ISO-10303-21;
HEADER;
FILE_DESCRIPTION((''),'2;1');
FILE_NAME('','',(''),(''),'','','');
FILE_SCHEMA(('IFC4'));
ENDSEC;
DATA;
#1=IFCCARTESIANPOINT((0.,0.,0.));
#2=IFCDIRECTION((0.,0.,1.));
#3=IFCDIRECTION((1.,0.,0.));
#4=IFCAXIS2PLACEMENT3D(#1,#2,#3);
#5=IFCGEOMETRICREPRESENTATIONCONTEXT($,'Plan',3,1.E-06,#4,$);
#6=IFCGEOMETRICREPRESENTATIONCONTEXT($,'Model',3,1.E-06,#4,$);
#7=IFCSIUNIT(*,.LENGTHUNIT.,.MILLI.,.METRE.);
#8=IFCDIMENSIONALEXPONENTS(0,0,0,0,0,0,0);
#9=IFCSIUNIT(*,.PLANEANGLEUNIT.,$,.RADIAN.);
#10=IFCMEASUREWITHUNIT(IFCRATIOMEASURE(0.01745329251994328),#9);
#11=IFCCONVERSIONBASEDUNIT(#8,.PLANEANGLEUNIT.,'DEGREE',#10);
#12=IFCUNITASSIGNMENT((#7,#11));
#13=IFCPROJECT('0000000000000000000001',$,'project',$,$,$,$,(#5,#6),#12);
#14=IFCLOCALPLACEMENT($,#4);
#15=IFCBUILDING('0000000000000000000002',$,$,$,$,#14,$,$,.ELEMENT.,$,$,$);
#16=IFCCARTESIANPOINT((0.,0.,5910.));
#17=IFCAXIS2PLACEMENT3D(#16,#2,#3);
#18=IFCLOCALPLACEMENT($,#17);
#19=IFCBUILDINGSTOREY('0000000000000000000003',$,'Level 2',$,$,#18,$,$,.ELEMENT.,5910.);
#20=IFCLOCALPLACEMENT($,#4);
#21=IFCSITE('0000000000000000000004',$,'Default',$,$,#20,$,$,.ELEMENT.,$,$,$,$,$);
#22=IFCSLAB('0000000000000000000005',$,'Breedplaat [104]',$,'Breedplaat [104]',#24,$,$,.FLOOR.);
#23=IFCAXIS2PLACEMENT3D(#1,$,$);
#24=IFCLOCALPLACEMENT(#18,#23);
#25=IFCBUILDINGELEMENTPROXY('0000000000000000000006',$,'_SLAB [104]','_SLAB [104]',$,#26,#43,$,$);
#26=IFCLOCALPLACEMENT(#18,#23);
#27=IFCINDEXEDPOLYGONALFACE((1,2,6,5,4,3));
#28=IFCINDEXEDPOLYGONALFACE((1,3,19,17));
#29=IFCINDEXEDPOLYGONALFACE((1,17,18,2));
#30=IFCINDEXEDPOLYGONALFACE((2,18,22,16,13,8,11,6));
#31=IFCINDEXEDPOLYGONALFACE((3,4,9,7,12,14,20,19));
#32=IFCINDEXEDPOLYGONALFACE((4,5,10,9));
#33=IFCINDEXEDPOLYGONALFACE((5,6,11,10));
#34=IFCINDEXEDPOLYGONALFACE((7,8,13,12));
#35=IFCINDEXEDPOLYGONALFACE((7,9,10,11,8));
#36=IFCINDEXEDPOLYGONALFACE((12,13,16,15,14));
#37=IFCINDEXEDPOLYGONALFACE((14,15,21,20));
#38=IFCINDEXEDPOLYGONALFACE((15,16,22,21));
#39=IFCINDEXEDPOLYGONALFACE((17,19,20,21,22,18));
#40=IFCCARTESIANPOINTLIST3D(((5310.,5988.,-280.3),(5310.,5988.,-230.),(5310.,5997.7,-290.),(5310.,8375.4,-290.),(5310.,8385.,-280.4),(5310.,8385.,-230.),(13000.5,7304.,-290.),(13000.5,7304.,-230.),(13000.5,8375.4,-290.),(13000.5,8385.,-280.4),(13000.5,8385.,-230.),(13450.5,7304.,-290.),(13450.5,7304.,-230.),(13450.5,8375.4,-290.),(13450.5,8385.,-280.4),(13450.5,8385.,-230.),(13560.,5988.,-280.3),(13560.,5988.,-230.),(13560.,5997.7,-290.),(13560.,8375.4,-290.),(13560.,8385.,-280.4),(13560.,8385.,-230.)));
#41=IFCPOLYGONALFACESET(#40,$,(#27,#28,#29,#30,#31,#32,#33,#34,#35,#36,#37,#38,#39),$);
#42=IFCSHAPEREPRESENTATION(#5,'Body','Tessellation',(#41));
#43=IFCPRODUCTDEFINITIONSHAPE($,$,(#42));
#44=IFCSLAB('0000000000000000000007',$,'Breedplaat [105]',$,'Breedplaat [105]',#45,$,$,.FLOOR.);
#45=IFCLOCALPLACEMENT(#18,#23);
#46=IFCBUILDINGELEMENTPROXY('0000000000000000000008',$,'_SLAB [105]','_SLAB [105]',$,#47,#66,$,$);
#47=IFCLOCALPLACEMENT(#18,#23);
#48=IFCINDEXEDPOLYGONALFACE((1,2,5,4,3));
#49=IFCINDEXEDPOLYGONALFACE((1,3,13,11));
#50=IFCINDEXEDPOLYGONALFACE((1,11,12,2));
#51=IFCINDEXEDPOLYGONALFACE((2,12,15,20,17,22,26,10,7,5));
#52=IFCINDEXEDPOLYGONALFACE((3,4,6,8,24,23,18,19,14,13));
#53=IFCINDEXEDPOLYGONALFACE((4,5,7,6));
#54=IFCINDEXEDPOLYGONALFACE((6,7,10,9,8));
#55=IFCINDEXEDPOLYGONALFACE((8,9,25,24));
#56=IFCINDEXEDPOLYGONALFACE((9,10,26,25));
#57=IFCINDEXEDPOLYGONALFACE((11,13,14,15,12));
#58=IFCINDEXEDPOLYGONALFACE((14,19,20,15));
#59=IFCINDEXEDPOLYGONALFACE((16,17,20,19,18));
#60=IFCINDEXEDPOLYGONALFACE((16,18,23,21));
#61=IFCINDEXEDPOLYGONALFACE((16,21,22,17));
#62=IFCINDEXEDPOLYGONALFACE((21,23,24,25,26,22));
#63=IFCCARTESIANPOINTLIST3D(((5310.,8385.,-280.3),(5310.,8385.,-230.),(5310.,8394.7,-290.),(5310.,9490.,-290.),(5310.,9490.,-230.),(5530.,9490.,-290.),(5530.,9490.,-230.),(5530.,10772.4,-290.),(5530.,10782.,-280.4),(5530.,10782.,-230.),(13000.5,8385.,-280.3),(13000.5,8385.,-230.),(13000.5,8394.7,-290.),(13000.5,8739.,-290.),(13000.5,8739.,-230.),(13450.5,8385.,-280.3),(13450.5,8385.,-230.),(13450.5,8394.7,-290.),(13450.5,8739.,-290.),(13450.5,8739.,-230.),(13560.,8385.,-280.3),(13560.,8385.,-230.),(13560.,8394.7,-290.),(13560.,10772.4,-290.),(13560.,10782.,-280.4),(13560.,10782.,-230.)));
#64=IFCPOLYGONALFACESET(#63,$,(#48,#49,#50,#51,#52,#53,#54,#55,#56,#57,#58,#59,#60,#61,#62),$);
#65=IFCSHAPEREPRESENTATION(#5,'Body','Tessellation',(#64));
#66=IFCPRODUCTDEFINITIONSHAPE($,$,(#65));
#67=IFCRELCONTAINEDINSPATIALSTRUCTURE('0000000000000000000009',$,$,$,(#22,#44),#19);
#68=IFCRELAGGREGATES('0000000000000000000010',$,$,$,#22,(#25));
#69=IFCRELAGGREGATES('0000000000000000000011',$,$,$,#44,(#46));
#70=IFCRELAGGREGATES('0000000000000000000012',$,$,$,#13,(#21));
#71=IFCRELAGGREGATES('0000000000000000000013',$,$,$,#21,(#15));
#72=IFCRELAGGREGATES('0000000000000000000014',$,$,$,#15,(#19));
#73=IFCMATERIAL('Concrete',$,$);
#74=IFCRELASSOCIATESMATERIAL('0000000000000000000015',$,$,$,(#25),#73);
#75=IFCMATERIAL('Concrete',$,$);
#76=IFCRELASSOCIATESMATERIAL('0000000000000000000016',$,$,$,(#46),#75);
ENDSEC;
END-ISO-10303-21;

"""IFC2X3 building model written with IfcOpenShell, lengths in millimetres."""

from ifc_helpers import new_model, entity, si_unit, converted_unit, frame, origin_with_axes, origin_2d_with_axis, place, context, project, spatial, polyline, rectangle, outline, extrude, material, element, aggregate, save


model = new_model("IFC2X3")

# Units and contexts
plan_context = context("Plan", 3, precision=1e-06, world=origin_with_axes())
model_context = context("Model", 3, precision=1e-06, world=origin_with_axes())
ifc_project = project(units=[si_unit("LENGTHUNIT", "METRE", prefix="MILLI"), converted_unit("PLANEANGLEUNIT", "DEGREE", entity("IfcRatioMeasure", 0.01745329251994328), si_unit("PLANEANGLEUNIT", "RADIAN"), dimensions=[0, 0, 0, 0, 0, 0, 0])], contexts=[plan_context, model_context])

# Site, building, storey
site_placement = place(None, origin_with_axes())
site = spatial("IfcSite", under=ifc_project, at=site_placement, Name="Default", CompositionType="ELEMENT")
building_placement = place(None, origin_with_axes())
building = spatial("IfcBuilding", under=site, at=building_placement, CompositionType="ELEMENT")
storey_placement = place(None, frame((0.0, 0.0, 5910.0), z_axis=(0.0, 0.0, 1.0), x_axis=(1.0, 0.0, 0.0)))
storey = spatial("IfcBuildingStorey", under=building, at=storey_placement, Name="Level 2", CompositionType="ELEMENT", Elevation=5910.0)

# Slabs, building element proxies, openings
slab_1_placement = place(None, frame((5310.0, 5988.0, 5620.0), z_axis=(0.0, 0.0, 1.0), x_axis=(1.0, 0.0, 0.0)))
slab_1 = element("IfcSlab", 1, at=slab_1_placement, inside=storey, Name="Breedplaat [104]", ObjectType="Breedplaat [104]", PredefinedType="FLOOR")
ifc_material_1 = material(Name="Concrete")
proxy_1_placement = place(slab_1_placement, origin_with_axes())
proxy_1 = element("IfcBuildingElementProxy", 2, at=proxy_1_placement, material=ifc_material_1, Name="_SLAB [104]", Description="_SLAB [104]", context=plan_context, shape_type="SweptSolid", body=[
    extrude(outline(polyline([(0.0, 0.0), (8250.0, 0.0), (8250.0, 2397.0), (0.0, 2397.0), (0.0, 0.0)])), origin_with_axes(), (0.0, 0.0, 1.0), 60.0),
])
opening_1_placement = place(slab_1_placement, frame((7690.5, 1316.0, 0.0), z_axis=(0.0, 0.0, 1.0), x_axis=(1.0, 0.0, 0.0)))
element("IfcOpeningElement", 3, at=opening_1_placement, cuts=proxy_1, ObjectType="Opening", context=plan_context, shape_type="SolidModel", body=[
    extrude(rectangle(XDim=450.0, YDim=1081.0, at=origin_2d_with_axis()), frame((225.0, 540.5, 0.0), z_axis=(0.0, 0.0, 1.0), x_axis=(1.0, 0.0, 0.0)), (0.0, 0.0, 1.0), 60.0),
])
opening_2_placement = place(None, frame((5310.0, 5988.0, 5620.0), z_axis=(0.0, 0.0, 1.0), x_axis=(1.0, 0.0, 0.0)))
element("IfcOpeningElement", 4, at=opening_2_placement, cuts=proxy_1, ObjectType="Opening", context=plan_context, shape_type="SweptSolid", body=[
    extrude(outline(polyline([(-0.1, -0.1), (-0.1, 10.0), (10.0, -0.1), (-0.1, -0.1)])), frame((-1.2, -0.1, -0.1), z_axis=(1.0, 0.0, 0.0), x_axis=(0.0, 1.0, 0.0)), (0.0, 0.0, 1.0), 8252.2),
])
opening_3_placement = place(None, frame((5310.0, 5988.0, 5620.0), z_axis=(0.0, 0.0, 1.0), x_axis=(1.0, 0.0, 0.0)))
element("IfcOpeningElement", 5, at=opening_3_placement, cuts=proxy_1, ObjectType="Opening", context=plan_context, shape_type="SweptSolid", body=[
    extrude(outline(polyline([(-0.1, -0.1), (-0.1, 10.0), (10.0, -0.1), (-0.1, -0.1)])), frame((8251.2, 2397.2, -0.1), z_axis=(-1.0, 0.0, 0.0), x_axis=(0.0, -1.0, 0.0)), (0.0, 0.0, 1.0), 8252.2),
])
aggregate(slab_1, [proxy_1])
slab_2_placement = place(None, frame((5310.0, 8385.0, 5620.0), z_axis=(0.0, 0.0, 1.0), x_axis=(1.0, 0.0, 0.0)))
slab_2 = element("IfcSlab", 6, at=slab_2_placement, inside=storey, Name="Breedplaat [105]", ObjectType="Breedplaat [105]", PredefinedType="FLOOR")
ifc_material_2 = material(Name="Concrete")
proxy_2_placement = place(slab_2_placement, origin_with_axes())
proxy_2 = element("IfcBuildingElementProxy", 7, at=proxy_2_placement, material=ifc_material_2, Name="_SLAB [105]", Description="_SLAB [105]", context=plan_context, shape_type="SweptSolid", body=[
    extrude(outline(polyline([(220.0, 2397.0), (220.0, 1105.0), (0.0, 1105.0), (0.0, 0.0), (8250.0, 0.0), (8250.0, 2397.0), (220.0, 2397.0)])), origin_with_axes(), (0.0, 0.0, 1.0), 60.0),
])
opening_4_placement = place(slab_2_placement, frame((7690.5, 0.0, 0.0), z_axis=(0.0, 0.0, 1.0), x_axis=(1.0, 0.0, 0.0)))
element("IfcOpeningElement", 8, at=opening_4_placement, cuts=proxy_2, ObjectType="Opening", context=plan_context, shape_type="SolidModel", body=[
    extrude(rectangle(XDim=450.0, YDim=354.0, at=origin_2d_with_axis()), frame((225.0, 177.0, 0.0), z_axis=(0.0, 0.0, 1.0), x_axis=(1.0, 0.0, 0.0)), (0.0, 0.0, 1.0), 60.0),
])
opening_5_placement = place(None, frame((5310.0, 8385.0, 5620.0), z_axis=(0.0, 0.0, 1.0), x_axis=(1.0, 0.0, 0.0)))
element("IfcOpeningElement", 9, at=opening_5_placement, cuts=proxy_2, ObjectType="Opening", context=plan_context, shape_type="SweptSolid", body=[
    extrude(outline(polyline([(-0.1, -0.1), (-0.1, 10.0), (10.0, -0.1), (-0.1, -0.1)])), frame((-1.2, -0.1, -0.1), z_axis=(1.0, 0.0, 0.0), x_axis=(0.0, 1.0, 0.0)), (0.0, 0.0, 1.0), 8252.2),
])
opening_6_placement = place(None, frame((5310.0, 8385.0, 5620.0), z_axis=(0.0, 0.0, 1.0), x_axis=(1.0, 0.0, 0.0)))
element("IfcOpeningElement", 10, at=opening_6_placement, cuts=proxy_2, ObjectType="Opening", context=plan_context, shape_type="SweptSolid", body=[
    extrude(outline(polyline([(-0.1, -0.1), (-0.1, 10.0), (10.0, -0.1), (-0.1, -0.1)])), frame((8251.2, 2397.2, -0.1), z_axis=(-1.0, 0.0, 0.0), x_axis=(0.0, -1.0, 0.0)), (0.0, 0.0, 1.0), 8032.2),
])
aggregate(slab_2, [proxy_2])

save(model, "model.ifc")
